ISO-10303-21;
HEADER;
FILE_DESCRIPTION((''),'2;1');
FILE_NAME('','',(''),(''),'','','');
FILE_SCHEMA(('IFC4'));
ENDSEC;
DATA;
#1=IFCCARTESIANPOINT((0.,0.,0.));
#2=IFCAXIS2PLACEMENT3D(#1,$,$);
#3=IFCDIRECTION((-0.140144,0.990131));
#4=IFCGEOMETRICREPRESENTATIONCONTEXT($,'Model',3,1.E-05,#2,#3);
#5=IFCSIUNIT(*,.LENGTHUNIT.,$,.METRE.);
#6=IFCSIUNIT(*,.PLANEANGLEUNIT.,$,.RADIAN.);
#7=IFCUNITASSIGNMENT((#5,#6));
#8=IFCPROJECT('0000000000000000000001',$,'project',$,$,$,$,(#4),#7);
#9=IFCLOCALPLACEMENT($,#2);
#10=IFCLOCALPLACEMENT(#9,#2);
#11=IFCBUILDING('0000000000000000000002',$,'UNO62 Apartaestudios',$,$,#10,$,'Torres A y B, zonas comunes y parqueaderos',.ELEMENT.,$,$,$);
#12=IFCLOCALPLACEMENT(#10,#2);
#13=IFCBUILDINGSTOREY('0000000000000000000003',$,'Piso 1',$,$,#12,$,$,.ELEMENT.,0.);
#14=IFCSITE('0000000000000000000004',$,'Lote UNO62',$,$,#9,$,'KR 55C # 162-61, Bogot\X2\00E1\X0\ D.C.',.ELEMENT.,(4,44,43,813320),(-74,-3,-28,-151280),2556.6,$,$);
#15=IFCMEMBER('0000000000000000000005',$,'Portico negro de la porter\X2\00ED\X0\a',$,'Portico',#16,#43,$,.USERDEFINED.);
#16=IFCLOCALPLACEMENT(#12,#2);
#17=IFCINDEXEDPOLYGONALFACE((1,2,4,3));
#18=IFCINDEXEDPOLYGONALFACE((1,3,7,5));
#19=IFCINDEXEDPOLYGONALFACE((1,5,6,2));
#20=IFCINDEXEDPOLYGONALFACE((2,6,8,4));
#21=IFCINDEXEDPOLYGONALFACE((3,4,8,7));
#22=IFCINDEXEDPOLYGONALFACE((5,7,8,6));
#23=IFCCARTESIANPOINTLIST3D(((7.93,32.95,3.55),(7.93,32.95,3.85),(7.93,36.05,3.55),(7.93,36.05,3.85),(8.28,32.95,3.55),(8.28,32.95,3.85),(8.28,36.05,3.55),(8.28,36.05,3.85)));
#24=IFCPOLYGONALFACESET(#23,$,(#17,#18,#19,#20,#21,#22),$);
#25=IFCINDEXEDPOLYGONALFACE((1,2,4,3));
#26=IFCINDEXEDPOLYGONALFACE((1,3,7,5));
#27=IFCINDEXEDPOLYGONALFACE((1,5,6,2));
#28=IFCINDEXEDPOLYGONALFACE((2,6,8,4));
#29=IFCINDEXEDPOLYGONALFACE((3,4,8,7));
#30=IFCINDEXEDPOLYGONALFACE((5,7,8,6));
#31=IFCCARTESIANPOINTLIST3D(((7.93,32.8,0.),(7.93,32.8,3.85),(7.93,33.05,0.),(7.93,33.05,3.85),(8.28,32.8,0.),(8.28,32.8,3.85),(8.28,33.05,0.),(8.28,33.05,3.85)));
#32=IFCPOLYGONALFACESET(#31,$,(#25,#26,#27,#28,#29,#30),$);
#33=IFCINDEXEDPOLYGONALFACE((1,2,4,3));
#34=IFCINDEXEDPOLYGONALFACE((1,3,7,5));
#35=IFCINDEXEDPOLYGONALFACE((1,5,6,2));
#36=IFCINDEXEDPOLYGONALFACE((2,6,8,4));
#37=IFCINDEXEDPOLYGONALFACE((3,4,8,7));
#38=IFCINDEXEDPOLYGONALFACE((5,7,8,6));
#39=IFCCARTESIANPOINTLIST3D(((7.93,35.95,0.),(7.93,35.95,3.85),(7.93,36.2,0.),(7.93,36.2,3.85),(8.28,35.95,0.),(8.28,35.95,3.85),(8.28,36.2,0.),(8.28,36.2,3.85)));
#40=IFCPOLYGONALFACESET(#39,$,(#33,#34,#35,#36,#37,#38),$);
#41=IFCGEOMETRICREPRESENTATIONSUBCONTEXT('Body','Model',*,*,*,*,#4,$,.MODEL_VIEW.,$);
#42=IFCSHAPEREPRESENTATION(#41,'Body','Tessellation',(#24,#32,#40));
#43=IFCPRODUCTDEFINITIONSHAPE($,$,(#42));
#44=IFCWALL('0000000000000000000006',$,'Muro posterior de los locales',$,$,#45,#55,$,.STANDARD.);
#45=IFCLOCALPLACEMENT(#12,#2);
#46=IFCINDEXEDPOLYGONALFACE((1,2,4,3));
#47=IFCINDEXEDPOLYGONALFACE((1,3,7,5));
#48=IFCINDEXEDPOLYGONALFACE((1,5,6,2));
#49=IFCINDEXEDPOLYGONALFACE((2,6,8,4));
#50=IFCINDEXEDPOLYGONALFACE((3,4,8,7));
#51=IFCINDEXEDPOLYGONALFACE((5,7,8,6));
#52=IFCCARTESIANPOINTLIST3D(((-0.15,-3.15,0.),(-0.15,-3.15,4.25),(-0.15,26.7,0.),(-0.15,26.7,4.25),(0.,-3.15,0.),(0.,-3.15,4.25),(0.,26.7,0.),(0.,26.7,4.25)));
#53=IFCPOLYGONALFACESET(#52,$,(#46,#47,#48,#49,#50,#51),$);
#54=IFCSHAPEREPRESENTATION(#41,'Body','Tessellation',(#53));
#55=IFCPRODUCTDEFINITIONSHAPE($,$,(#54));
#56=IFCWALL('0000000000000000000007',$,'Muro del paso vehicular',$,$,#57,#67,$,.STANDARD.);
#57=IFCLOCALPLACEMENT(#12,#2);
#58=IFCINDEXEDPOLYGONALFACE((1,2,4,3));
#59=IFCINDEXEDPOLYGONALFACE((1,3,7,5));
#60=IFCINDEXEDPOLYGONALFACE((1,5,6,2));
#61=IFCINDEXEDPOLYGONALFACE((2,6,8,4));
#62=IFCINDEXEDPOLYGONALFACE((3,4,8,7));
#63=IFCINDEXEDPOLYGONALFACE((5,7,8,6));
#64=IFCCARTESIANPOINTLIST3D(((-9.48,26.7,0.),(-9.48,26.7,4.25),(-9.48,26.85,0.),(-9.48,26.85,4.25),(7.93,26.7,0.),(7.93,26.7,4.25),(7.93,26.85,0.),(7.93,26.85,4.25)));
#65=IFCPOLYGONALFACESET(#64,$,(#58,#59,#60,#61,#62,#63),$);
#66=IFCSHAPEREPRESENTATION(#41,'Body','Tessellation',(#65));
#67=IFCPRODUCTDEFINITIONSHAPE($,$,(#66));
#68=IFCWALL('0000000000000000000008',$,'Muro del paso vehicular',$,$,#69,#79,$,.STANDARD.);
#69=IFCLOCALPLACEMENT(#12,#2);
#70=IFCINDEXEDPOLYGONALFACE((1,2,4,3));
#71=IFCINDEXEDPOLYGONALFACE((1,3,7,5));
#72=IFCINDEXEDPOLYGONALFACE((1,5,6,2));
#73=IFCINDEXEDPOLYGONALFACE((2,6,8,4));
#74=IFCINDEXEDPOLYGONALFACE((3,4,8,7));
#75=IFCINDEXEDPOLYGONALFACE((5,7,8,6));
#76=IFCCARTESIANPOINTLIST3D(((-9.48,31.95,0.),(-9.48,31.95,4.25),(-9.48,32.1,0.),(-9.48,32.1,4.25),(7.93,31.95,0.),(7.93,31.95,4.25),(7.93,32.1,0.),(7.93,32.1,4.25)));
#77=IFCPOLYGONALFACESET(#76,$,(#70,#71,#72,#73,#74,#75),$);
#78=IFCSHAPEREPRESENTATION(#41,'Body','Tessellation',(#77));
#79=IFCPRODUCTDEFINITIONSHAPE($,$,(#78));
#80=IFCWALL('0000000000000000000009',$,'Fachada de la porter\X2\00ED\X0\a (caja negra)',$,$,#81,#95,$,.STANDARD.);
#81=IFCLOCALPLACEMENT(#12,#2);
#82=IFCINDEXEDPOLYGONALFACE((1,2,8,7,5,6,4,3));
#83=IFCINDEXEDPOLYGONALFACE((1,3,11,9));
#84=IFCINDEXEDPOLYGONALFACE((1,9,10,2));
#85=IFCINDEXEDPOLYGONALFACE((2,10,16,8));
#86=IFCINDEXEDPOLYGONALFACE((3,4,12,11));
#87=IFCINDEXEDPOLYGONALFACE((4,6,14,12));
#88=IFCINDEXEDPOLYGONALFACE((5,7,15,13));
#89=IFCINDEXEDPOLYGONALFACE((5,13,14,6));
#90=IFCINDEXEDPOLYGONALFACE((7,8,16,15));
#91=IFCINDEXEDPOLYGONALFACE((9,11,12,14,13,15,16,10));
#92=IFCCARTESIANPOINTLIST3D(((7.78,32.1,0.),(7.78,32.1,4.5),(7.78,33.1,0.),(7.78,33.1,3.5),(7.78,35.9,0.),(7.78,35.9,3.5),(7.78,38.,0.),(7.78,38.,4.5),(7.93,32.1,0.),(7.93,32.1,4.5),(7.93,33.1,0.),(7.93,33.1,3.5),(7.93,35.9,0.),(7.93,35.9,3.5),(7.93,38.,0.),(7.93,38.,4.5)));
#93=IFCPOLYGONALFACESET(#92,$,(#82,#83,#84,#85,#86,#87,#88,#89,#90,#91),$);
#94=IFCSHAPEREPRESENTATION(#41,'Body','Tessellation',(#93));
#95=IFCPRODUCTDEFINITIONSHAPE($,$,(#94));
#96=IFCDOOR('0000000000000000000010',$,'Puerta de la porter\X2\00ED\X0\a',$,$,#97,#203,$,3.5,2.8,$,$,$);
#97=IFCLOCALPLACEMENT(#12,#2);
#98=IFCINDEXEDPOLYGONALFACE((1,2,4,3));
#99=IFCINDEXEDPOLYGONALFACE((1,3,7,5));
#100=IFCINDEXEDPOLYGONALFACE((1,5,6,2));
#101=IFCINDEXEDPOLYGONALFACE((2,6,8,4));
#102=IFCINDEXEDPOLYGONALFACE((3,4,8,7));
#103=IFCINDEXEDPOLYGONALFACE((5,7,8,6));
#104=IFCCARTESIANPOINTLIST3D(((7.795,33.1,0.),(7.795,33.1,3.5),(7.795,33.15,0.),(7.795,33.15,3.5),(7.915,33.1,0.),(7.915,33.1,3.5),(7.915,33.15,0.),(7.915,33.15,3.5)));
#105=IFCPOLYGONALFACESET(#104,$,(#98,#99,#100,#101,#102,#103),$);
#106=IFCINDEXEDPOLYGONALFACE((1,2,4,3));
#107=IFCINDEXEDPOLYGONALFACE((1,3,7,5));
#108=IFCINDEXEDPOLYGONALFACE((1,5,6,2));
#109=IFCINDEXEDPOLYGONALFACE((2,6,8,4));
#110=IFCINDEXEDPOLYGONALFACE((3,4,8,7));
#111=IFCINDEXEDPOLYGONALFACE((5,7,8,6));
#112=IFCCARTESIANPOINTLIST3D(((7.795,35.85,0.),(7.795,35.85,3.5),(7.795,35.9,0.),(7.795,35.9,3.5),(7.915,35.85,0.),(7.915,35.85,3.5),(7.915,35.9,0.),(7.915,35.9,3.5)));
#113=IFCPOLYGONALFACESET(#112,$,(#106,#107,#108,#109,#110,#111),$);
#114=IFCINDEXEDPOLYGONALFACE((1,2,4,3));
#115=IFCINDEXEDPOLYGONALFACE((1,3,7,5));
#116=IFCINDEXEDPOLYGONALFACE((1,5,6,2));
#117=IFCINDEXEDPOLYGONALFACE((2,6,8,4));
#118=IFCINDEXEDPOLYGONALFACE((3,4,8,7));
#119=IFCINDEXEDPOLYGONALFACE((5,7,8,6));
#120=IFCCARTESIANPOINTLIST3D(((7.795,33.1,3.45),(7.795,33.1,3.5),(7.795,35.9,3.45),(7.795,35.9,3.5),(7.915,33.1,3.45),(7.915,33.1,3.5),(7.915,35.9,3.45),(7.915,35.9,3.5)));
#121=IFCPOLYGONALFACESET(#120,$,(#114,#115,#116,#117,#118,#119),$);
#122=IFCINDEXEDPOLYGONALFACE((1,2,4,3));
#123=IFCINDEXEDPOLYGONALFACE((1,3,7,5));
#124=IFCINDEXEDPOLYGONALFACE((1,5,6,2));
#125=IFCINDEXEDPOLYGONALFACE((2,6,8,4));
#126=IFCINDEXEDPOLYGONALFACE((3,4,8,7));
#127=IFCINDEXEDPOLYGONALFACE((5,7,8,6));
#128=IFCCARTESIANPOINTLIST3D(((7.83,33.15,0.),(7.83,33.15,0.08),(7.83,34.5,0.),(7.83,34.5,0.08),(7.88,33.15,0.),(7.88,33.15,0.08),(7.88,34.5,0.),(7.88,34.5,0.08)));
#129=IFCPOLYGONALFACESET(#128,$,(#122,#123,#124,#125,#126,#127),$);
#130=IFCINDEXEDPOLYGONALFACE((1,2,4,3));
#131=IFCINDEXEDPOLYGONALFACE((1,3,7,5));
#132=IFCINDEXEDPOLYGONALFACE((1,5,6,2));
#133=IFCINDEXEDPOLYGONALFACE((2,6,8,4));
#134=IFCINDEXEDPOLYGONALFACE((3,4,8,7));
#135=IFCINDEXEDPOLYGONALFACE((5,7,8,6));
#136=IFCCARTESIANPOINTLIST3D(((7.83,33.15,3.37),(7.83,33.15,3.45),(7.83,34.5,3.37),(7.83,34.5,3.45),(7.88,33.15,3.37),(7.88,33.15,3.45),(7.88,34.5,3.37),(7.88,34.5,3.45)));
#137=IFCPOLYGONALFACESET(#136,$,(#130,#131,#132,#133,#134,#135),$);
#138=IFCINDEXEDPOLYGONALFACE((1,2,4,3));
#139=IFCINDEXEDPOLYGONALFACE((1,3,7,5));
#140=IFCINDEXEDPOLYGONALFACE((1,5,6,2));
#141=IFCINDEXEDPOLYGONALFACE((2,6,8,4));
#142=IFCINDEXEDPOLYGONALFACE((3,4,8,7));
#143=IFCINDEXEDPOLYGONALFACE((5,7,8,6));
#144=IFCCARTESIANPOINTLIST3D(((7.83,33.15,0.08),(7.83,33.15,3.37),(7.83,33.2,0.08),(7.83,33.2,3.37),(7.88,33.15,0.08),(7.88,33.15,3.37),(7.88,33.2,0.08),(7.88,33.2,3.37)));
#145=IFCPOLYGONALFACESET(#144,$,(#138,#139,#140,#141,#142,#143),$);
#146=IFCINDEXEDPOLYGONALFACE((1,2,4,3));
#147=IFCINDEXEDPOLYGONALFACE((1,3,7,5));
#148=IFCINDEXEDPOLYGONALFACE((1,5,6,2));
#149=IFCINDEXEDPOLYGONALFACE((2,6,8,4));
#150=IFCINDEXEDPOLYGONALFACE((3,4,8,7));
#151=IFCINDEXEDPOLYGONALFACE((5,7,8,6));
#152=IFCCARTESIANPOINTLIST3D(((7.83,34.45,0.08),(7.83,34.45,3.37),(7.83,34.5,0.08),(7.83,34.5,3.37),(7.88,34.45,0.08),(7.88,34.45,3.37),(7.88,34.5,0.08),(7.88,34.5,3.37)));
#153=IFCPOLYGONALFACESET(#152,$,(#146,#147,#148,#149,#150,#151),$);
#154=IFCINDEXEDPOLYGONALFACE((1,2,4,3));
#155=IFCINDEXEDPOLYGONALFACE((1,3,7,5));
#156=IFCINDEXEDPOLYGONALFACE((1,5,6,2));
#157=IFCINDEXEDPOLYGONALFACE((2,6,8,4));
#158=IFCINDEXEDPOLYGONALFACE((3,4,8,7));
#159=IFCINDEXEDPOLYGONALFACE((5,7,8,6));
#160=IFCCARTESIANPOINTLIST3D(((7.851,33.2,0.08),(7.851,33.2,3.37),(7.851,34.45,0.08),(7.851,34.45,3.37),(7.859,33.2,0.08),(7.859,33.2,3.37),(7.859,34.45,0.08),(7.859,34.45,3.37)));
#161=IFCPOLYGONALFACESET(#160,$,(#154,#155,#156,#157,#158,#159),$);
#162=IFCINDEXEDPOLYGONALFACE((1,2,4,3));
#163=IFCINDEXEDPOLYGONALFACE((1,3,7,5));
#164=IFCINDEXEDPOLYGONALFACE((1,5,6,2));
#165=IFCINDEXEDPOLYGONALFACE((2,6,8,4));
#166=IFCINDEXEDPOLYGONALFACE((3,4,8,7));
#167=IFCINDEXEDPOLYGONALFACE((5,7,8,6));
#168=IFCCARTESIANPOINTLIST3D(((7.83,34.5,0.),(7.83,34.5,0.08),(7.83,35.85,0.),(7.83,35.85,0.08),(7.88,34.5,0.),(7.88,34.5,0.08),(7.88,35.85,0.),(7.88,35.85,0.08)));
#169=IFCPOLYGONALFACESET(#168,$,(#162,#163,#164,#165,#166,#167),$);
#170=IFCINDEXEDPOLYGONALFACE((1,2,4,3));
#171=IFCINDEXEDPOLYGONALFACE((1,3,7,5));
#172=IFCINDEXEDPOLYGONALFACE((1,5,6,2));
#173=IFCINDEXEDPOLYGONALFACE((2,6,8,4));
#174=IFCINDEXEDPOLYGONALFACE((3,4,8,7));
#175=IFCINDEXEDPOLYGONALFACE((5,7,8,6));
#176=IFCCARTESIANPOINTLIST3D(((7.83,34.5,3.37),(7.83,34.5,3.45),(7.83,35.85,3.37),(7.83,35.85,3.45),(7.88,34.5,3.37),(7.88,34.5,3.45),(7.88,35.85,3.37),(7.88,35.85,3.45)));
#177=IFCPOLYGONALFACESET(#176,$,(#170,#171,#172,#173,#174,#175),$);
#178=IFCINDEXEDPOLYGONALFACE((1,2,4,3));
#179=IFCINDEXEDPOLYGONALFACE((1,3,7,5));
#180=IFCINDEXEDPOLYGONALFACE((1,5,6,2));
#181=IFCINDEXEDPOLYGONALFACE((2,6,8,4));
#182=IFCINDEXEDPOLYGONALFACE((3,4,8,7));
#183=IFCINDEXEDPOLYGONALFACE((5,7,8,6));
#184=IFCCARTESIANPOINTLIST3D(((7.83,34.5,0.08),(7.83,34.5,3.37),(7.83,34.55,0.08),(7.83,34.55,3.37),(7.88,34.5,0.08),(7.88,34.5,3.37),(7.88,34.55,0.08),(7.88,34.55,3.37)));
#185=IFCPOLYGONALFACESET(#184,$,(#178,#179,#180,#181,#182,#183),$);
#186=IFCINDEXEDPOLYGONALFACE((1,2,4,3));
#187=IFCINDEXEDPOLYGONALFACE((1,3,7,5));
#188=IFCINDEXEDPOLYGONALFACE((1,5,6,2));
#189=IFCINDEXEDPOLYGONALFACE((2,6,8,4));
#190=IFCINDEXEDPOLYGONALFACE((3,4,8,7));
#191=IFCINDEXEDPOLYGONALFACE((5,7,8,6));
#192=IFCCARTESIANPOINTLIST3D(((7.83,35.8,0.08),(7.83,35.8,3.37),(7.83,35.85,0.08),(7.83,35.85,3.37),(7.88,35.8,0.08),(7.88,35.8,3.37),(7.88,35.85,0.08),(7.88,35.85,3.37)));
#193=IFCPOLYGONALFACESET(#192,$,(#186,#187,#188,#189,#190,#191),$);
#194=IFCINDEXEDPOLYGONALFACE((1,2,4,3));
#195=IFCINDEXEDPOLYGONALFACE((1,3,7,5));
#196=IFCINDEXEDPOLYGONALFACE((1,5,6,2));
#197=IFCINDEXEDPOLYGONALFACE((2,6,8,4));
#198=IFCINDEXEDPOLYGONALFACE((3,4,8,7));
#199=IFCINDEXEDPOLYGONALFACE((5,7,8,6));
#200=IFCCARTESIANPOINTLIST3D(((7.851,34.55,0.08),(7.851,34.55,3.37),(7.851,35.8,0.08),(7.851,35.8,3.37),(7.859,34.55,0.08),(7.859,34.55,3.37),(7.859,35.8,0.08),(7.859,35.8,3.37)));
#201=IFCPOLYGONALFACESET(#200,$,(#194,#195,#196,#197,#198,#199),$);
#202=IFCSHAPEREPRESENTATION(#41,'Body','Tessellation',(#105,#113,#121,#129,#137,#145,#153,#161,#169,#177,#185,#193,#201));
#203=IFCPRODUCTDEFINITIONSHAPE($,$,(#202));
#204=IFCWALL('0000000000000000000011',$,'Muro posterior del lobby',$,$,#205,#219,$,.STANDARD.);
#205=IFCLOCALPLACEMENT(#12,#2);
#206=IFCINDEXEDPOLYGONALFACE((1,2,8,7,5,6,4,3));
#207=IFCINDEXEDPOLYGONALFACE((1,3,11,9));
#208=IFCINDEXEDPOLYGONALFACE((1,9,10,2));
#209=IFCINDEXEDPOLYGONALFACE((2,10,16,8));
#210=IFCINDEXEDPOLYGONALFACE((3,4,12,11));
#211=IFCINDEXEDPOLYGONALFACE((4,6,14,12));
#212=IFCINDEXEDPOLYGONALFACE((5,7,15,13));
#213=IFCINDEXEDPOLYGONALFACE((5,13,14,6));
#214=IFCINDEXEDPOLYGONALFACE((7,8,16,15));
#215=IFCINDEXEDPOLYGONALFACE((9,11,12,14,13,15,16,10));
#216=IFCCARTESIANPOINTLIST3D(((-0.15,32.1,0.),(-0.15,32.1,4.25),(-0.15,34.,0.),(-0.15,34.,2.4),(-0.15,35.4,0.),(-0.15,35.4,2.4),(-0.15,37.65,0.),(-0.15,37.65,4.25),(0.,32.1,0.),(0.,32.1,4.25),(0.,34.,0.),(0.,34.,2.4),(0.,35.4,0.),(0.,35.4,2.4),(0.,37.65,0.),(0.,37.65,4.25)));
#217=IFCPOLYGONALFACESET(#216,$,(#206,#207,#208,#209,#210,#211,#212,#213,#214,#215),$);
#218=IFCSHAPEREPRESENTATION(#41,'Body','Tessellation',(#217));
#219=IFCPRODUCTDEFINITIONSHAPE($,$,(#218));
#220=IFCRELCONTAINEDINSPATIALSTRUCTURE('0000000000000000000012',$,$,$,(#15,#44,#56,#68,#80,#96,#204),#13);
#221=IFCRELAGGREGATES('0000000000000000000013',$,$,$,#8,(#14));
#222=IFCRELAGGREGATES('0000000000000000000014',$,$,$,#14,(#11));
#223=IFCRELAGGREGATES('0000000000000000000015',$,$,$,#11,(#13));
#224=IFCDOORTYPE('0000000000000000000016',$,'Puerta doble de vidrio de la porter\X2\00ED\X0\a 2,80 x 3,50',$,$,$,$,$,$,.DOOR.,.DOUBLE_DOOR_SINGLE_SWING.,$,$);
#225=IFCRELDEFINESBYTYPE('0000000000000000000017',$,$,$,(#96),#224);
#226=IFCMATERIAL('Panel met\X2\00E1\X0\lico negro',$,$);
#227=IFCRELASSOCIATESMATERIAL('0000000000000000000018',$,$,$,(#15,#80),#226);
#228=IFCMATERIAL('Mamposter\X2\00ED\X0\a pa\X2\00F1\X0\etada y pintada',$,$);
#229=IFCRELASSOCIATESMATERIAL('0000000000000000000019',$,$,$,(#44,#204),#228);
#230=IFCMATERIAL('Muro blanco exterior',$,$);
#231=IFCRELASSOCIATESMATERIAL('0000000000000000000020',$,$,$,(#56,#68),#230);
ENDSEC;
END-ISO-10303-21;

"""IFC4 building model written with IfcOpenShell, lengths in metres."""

from ifc_helpers import new_model, si_unit, direction, frame, frame_2d, origin, place, context, subcontext, project, spatial, rectangle, extrude, source, transform, mapped, material, type_object, type_shapes, element, fill, save


model = new_model("IFC4")

# Units and contexts
model_context = context("Model", 3, precision=1e-05, world=origin(), true_north=direction((-0.140144, 0.990131)))
body_context = subcontext(model_context, "Body", "Model", "MODEL_VIEW")
ifc_project = project(units=[si_unit("LENGTHUNIT", "METRE"), si_unit("PLANEANGLEUNIT", "RADIAN")], contexts=[model_context])

# Site, building, storey
site_placement = place(None, origin())
site = spatial("IfcSite", under=ifc_project, at=site_placement, Name="Lote UNO62", LongName="KR 55C # 162-61, Bogotá D.C.", CompositionType="ELEMENT", RefLatitude=(4, 44, 43, 813320), RefLongitude=(-74, -3, -28, -151280), RefElevation=2556.6)
building_placement = place(site_placement, origin())
building = spatial("IfcBuilding", under=site, at=building_placement, Name="UNO62 Apartaestudios", LongName="Torres A y B, zonas comunes y parqueaderos", CompositionType="ELEMENT")
storey_placement = place(building_placement, origin())
storey = spatial("IfcBuildingStorey", under=building, at=storey_placement, Name="Piso 1", CompositionType="ELEMENT", Elevation=0.0)

# Member
ifc_material_1 = material(Name="Panel metálico negro")
member_placement = place(storey_placement, origin())
element("IfcMember", 1, at=member_placement, inside=storey, material=ifc_material_1, Name="Portico negro de la portería", ObjectType="Portico", PredefinedType="USERDEFINED", context=body_context, shape_type="SweptSolid", body=[
    extrude(rectangle(XDim=0.35, YDim=3.1, at=frame_2d((8.105, 34.5))), frame((0.0, 0.0, 3.55)), (0.0, 0.0, 1.0), 0.3),
    extrude(rectangle(XDim=0.35, YDim=0.25, at=frame_2d((8.105, 32.925))), origin(), (0.0, 0.0, 1.0), 3.85),
    extrude(rectangle(XDim=0.35, YDim=0.25, at=frame_2d((8.105, 36.075))), origin(), (0.0, 0.0, 1.0), 3.85),
])

# Walls
ifc_material_2 = material(Name="Mampostería pañetada y pintada")
wall_1_placement = place(storey_placement, origin())
element("IfcWall", 2, at=wall_1_placement, inside=storey, material=ifc_material_2, Name="Muro posterior de los locales", PredefinedType="STANDARD", context=body_context, shape_type="SweptSolid", body=[
    extrude(rectangle(XDim=0.15, YDim=29.85, at=frame_2d((-0.075, 11.775))), origin(), (0.0, 0.0, 1.0), 4.25),
])
ifc_material_3 = material(Name="Muro blanco exterior")
wall_2_placement = place(storey_placement, origin())
element("IfcWall", 3, at=wall_2_placement, inside=storey, material=ifc_material_3, Name="Muro del paso vehicular", PredefinedType="STANDARD", context=body_context, shape_type="SweptSolid", body=[
    extrude(rectangle(XDim=17.41, YDim=0.15, at=frame_2d((-0.775, 26.775))), origin(), (0.0, 0.0, 1.0), 4.25),
])
wall_3_placement = place(storey_placement, origin())
element("IfcWall", 4, at=wall_3_placement, inside=storey, material=ifc_material_3, Name="Muro del paso vehicular", PredefinedType="STANDARD", context=body_context, shape_type="SweptSolid", body=[
    extrude(rectangle(XDim=17.41, YDim=0.15, at=frame_2d((-0.775, 32.025))), origin(), (0.0, 0.0, 1.0), 4.25),
])

# Wall, opening, door
wall_4_placement = place(storey_placement, origin())
wall_4 = element("IfcWall", 5, at=wall_4_placement, inside=storey, material=ifc_material_1, Name="Fachada de la portería (caja negra)", PredefinedType="STANDARD", context=body_context, shape_type="SweptSolid", body=[
    extrude(rectangle(XDim=0.15, YDim=5.9, at=frame_2d((7.855, 35.05))), origin(), (0.0, 0.0, 1.0), 4.5),
])
opening_1_placement = place(wall_4_placement, origin())
opening_1 = element("IfcOpeningElement", 6, at=opening_1_placement, cuts=wall_4, PredefinedType="OPENING", context=body_context, shape_type="SweptSolid", body=[
    extrude(rectangle(XDim=0.25, YDim=2.8, at=frame_2d((7.855, 34.5))), origin(), (0.0, 0.0, 1.0), 3.5),
])
door_type_1 = type_object("IfcDoorType", Name="Puerta doble de vidrio de la portería 2,80 x 3,50", OperationType="DOUBLE_DOOR_SINGLE_SWING", PredefinedType="DOOR")
shared_shape_1 = source(origin(), body_context, "Body", "SweptSolid", [
    extrude(rectangle(XDim=0.05, YDim=0.12, at=frame_2d((0.025, 0.0))), origin(), (0.0, 0.0, 1.0), 3.5),
    extrude(rectangle(XDim=0.05, YDim=0.12, at=frame_2d((2.775, 0.0))), origin(), (0.0, 0.0, 1.0), 3.5),
    extrude(rectangle(XDim=2.8, YDim=0.12, at=frame_2d((1.4, 0.0))), frame((0.0, 0.0, 3.45)), (0.0, 0.0, 1.0), 0.05),
    extrude(rectangle(XDim=1.35, YDim=0.05, at=frame_2d((0.725, 0.0))), origin(), (0.0, 0.0, 1.0), 0.08),
    extrude(rectangle(XDim=1.35, YDim=0.05, at=frame_2d((0.725, 0.0))), frame((0.0, 0.0, 3.37)), (0.0, 0.0, 1.0), 0.08),
    extrude(rectangle(XDim=0.05, YDim=0.05, at=frame_2d((0.075, 0.0))), frame((0.0, 0.0, 0.08)), (0.0, 0.0, 1.0), 3.29),
    extrude(rectangle(XDim=0.05, YDim=0.05, at=frame_2d((1.375, 0.0))), frame((0.0, 0.0, 0.08)), (0.0, 0.0, 1.0), 3.29),
    extrude(rectangle(XDim=1.25, YDim=0.008, at=frame_2d((0.725, 0.0))), frame((0.0, 0.0, 0.08)), (0.0, 0.0, 1.0), 3.29),
    extrude(rectangle(XDim=1.35, YDim=0.05, at=frame_2d((2.075, 0.0))), origin(), (0.0, 0.0, 1.0), 0.08),
    extrude(rectangle(XDim=1.35, YDim=0.05, at=frame_2d((2.075, 0.0))), frame((0.0, 0.0, 3.37)), (0.0, 0.0, 1.0), 0.08),
    extrude(rectangle(XDim=0.05, YDim=0.05, at=frame_2d((1.425, 0.0))), frame((0.0, 0.0, 0.08)), (0.0, 0.0, 1.0), 3.29),
    extrude(rectangle(XDim=0.05, YDim=0.05, at=frame_2d((2.725, 0.0))), frame((0.0, 0.0, 0.08)), (0.0, 0.0, 1.0), 3.29),
    extrude(rectangle(XDim=1.25, YDim=0.008, at=frame_2d((2.075, 0.0))), frame((0.0, 0.0, 0.08)), (0.0, 0.0, 1.0), 3.29),
])
type_shapes(door_type_1, [shared_shape_1])
door_1_placement = place(storey_placement, frame((7.855, 33.1, 0.0), z_axis=(0.0, 0.0, 1.0), x_axis=(0.0, 1.0, 0.0)))
door_1 = element("IfcDoor", 7, at=door_1_placement, inside=storey, type_object=door_type_1, Name="Puerta de la portería", OverallHeight=3.5, OverallWidth=2.8, context=body_context, shape_type="MappedRepresentation", body=[
    mapped(shared_shape_1, transform((0.0, 0.0, 0.0))),
])
fill(opening_1, door_1)

# Wall, opening
wall_5_placement = place(storey_placement, origin())
wall_5 = element("IfcWall", 8, at=wall_5_placement, inside=storey, material=ifc_material_2, Name="Muro posterior del lobby", PredefinedType="STANDARD", context=body_context, shape_type="SweptSolid", body=[
    extrude(rectangle(XDim=0.15, YDim=5.55, at=frame_2d((-0.075, 34.875))), origin(), (0.0, 0.0, 1.0), 4.25),
])
opening_2_placement = place(wall_5_placement, origin())
element("IfcOpeningElement", 9, at=opening_2_placement, cuts=wall_5, PredefinedType="OPENING", context=body_context, shape_type="SweptSolid", body=[
    extrude(rectangle(XDim=0.25, YDim=1.4, at=frame_2d((-0.075, 34.7))), origin(), (0.0, 0.0, 1.0), 2.4),
])

save(model, "model.ifc")
